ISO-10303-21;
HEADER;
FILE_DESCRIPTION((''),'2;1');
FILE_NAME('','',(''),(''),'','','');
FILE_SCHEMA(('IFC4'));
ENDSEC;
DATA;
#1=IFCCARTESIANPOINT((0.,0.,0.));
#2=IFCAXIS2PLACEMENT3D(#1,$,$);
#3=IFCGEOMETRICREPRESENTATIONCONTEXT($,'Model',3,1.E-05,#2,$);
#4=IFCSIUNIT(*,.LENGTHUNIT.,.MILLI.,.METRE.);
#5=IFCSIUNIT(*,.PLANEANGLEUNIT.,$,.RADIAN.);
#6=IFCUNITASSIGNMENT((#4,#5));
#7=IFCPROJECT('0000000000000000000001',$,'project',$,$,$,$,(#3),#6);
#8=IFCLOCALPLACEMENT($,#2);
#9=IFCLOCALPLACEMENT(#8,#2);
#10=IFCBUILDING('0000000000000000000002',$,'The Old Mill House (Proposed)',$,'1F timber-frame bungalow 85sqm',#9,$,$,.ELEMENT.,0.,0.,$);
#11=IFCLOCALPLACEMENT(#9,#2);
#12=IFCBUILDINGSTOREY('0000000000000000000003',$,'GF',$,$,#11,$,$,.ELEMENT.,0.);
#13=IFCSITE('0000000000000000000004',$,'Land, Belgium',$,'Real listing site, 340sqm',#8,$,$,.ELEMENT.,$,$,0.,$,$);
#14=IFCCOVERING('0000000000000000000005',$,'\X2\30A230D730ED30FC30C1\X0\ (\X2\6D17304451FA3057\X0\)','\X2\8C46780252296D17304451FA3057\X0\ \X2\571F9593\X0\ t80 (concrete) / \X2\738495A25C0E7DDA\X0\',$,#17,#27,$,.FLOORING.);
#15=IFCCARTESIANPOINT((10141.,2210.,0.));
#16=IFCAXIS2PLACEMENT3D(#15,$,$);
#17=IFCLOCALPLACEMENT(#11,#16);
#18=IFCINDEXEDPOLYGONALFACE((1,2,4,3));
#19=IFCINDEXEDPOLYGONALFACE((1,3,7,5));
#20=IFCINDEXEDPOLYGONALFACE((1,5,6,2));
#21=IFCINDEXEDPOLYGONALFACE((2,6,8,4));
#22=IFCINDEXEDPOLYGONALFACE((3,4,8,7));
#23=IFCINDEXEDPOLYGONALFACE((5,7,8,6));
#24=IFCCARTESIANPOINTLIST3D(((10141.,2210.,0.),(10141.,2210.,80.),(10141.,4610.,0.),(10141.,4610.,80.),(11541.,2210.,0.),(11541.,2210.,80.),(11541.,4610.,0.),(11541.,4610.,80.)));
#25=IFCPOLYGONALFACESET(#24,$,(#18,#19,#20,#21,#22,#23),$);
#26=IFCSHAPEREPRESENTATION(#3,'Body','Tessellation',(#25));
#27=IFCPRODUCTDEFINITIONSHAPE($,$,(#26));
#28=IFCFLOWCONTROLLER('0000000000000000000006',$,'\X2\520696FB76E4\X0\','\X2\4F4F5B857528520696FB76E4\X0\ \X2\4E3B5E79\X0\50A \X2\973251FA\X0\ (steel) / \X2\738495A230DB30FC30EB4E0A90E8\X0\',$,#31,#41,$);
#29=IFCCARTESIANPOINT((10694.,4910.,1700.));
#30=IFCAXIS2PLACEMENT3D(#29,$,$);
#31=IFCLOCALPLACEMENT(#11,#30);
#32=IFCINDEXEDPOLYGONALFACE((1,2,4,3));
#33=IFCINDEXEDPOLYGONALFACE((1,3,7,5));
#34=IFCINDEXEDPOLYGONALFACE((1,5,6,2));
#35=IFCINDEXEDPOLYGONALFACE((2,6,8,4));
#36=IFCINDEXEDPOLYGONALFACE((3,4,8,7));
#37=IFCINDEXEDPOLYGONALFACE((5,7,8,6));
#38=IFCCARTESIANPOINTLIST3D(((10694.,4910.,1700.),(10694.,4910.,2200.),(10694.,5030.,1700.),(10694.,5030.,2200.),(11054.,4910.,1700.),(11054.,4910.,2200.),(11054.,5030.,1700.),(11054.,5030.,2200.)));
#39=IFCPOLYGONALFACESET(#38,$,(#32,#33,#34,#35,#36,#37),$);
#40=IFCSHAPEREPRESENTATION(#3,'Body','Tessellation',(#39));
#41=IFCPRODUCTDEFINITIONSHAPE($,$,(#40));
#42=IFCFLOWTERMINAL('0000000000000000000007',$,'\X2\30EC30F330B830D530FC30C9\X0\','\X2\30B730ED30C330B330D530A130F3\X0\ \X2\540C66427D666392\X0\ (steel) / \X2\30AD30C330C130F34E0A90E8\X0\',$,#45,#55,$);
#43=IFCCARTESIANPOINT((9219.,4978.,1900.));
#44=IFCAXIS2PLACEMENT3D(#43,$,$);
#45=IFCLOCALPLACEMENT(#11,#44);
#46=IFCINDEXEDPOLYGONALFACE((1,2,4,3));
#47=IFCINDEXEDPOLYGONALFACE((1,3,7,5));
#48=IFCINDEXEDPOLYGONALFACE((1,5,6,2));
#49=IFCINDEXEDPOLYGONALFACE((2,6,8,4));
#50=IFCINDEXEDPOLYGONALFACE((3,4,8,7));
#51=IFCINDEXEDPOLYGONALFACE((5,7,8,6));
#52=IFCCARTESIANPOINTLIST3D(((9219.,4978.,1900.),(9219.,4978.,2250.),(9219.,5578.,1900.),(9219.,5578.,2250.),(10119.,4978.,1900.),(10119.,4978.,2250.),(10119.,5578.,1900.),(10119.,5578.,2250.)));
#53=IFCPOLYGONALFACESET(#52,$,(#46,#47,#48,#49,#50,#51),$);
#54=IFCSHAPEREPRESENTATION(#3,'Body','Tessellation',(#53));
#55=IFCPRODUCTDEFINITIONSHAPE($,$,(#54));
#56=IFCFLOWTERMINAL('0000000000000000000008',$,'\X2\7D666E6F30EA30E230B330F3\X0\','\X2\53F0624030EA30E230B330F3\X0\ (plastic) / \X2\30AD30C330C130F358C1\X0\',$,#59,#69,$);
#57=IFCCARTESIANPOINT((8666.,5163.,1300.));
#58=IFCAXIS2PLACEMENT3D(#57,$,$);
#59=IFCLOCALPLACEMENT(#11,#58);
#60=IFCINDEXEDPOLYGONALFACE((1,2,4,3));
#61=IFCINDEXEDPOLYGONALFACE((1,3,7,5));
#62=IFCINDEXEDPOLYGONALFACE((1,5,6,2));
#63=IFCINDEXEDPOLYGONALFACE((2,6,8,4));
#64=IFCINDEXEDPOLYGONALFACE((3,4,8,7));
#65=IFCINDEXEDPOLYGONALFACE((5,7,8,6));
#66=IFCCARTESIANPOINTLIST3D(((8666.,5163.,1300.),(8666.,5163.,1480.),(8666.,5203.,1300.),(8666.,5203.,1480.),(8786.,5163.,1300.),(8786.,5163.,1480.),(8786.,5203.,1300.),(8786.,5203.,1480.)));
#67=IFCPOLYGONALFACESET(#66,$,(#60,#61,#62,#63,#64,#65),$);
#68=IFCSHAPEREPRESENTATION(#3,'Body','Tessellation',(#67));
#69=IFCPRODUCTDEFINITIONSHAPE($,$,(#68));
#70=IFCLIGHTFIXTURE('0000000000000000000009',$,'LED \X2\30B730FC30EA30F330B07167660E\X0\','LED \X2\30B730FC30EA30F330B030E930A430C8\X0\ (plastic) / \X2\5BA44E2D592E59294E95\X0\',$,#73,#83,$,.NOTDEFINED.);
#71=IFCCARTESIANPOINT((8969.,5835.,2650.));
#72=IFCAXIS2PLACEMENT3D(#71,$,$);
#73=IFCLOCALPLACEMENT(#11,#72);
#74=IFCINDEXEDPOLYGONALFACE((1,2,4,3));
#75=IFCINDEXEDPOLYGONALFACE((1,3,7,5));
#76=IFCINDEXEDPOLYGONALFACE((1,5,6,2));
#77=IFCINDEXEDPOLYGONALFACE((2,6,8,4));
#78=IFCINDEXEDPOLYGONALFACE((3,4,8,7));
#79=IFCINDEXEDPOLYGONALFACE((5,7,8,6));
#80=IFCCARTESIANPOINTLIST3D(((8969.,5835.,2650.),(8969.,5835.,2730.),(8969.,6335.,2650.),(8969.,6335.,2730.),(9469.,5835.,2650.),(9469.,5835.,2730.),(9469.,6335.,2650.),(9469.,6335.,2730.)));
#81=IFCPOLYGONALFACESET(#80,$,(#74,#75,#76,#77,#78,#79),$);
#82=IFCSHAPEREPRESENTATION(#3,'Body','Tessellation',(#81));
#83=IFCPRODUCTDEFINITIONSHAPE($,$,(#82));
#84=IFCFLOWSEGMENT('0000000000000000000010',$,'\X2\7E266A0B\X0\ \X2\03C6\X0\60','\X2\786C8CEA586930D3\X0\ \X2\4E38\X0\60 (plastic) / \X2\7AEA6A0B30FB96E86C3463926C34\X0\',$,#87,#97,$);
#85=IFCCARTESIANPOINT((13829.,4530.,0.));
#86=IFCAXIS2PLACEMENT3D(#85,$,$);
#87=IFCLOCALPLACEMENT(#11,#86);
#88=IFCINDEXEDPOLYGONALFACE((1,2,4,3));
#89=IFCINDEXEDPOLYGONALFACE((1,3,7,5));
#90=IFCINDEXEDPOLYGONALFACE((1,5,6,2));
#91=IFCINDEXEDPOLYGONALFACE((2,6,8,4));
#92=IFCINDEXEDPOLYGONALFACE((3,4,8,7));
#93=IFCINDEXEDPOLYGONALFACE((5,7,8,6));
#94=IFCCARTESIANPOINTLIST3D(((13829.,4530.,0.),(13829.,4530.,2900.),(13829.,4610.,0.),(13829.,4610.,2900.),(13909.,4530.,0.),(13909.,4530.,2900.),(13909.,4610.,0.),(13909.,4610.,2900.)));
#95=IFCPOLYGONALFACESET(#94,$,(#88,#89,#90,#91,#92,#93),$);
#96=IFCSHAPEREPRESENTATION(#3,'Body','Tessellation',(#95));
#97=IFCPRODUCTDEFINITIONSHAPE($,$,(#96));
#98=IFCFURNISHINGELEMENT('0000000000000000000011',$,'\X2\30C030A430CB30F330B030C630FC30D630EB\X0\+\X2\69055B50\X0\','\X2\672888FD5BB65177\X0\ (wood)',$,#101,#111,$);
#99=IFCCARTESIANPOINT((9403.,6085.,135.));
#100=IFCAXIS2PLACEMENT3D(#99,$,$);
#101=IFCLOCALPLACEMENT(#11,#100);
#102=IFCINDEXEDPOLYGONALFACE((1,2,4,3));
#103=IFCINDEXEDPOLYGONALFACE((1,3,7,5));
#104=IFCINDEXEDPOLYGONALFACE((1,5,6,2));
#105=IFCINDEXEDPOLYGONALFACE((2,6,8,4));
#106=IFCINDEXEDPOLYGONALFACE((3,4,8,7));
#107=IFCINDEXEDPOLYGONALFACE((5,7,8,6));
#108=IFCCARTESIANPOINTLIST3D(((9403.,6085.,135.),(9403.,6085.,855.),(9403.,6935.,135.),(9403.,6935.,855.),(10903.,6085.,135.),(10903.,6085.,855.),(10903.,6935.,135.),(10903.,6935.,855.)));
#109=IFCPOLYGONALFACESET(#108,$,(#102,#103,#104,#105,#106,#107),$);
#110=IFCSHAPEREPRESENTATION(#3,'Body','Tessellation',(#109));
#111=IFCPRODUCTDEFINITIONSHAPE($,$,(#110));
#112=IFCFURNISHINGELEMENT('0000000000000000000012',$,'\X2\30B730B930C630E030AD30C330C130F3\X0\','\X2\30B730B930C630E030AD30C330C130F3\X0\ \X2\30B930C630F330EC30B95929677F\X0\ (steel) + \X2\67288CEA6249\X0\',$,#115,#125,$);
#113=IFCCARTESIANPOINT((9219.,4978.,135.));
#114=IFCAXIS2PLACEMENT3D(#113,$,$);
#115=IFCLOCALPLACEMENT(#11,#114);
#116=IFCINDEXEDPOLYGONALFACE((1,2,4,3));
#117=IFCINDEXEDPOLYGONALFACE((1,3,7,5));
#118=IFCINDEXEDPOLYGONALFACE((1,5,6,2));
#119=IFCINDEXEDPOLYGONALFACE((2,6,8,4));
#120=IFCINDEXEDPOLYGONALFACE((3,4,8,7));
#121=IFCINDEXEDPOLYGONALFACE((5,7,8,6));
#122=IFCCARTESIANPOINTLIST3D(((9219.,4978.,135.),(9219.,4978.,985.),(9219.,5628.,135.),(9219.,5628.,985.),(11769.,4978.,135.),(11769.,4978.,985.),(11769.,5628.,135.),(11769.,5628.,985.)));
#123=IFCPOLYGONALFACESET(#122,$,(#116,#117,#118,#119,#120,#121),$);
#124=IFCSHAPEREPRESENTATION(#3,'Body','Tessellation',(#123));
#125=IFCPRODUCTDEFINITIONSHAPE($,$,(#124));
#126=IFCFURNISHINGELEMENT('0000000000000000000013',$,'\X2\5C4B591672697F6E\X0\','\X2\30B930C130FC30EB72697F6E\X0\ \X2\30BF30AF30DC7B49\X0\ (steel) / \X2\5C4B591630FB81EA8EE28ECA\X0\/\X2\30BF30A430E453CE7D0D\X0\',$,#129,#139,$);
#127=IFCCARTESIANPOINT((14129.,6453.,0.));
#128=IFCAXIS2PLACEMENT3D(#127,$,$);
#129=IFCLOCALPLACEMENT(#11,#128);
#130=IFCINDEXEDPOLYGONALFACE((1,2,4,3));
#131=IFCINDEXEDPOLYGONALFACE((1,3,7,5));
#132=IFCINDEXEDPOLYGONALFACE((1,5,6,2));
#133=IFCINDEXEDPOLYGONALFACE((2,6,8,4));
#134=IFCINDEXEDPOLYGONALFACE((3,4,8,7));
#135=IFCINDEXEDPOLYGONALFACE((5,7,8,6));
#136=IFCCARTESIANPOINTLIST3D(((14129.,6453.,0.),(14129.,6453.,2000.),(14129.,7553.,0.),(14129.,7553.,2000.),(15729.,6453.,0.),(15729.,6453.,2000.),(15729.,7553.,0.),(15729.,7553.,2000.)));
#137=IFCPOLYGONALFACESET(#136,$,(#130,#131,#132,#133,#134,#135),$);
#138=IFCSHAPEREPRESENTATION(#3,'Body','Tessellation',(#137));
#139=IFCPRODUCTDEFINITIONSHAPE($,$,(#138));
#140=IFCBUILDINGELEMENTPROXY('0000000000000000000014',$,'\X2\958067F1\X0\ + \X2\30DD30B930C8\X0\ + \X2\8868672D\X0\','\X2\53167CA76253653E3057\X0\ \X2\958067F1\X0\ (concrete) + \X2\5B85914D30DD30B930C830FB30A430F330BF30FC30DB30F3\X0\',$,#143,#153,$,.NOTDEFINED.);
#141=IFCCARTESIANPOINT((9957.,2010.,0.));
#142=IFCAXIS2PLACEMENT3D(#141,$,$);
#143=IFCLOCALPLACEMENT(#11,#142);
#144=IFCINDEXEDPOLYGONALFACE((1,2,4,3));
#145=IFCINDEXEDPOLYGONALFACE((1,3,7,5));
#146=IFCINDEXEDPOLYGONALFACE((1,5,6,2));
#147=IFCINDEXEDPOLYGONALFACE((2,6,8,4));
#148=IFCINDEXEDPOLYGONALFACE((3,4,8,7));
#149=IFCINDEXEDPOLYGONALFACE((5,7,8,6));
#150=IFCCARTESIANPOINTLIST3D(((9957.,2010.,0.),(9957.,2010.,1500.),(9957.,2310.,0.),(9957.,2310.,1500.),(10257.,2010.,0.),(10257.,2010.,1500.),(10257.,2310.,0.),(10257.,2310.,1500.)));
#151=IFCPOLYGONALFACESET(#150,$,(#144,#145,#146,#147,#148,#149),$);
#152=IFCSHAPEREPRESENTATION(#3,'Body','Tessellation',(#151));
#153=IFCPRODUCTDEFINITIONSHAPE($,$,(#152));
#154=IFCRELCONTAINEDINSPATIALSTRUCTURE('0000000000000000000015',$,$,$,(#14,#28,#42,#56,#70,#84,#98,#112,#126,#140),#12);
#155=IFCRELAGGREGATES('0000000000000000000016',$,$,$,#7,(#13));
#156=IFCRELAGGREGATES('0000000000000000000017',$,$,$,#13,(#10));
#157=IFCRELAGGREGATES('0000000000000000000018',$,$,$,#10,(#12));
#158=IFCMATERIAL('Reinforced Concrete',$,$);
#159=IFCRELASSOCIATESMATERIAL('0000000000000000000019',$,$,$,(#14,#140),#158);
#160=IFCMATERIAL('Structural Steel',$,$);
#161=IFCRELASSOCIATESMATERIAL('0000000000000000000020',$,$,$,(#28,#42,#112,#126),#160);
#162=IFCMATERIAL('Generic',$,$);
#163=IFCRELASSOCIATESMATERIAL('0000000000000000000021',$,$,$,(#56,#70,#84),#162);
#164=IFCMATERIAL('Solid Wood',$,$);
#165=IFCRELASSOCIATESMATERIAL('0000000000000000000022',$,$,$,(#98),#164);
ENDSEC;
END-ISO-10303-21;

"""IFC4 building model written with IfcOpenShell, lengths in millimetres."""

from ifc_helpers import new_model, si_unit, frame, frame_2d, origin, place, context, project, spatial, rectangle, extrude, material, element, save


model = new_model("IFC4")

# Units and contexts
model_context = context("Model", 3, precision=1e-05, world=origin())
ifc_project = project(units=[si_unit("LENGTHUNIT", "METRE", prefix="MILLI"), si_unit("PLANEANGLEUNIT", "RADIAN")], contexts=[model_context])

# Site, building, storey
site_placement = place(None, origin())
site = spatial("IfcSite", under=ifc_project, at=site_placement, Name="Land, Belgium", ObjectType="Real listing site, 340sqm", CompositionType="ELEMENT", RefElevation=0.0)
building_placement = place(site_placement, origin())
building = spatial("IfcBuilding", under=site, at=building_placement, Name="The Old Mill House (Proposed)", ObjectType="1F timber-frame bungalow 85sqm", CompositionType="ELEMENT", ElevationOfRefHeight=0.0, ElevationOfTerrain=0.0)
storey_placement = place(building_placement, origin())
storey = spatial("IfcBuildingStorey", under=building, at=storey_placement, Name="GF", CompositionType="ELEMENT", Elevation=0.0)

# Shared definitions
ifc_material_1 = material(Name="Solid Wood")

# Shared definitions
ifc_material_2 = material(Name="Structural Steel")

# Covering
ifc_material_3 = material(Name="Reinforced Concrete")
covering_placement = place(storey_placement, frame((10141.0, 2210.0, 0.0)))
element("IfcCovering", 1, at=covering_placement, inside=storey, material=ifc_material_3, Name="アプローチ (洗い出し)", Description="豆砂利洗い出し 土間 t80 (concrete) / 玄関導線", PredefinedType="FLOORING", context=model_context, shape_type="SweptSolid", body=[
    extrude(rectangle(XDim=1400.0, YDim=2400.0, at=frame_2d((700.0, 1200.0))), frame((10141.0, 2210.0, 0.0)), (0.0, 0.0, 1.0), 80.0),
])

# Flow controller
flow_controller_placement = place(storey_placement, frame((10694.0, 4910.0, 1700.0)))
element("IfcFlowController", 2, at=flow_controller_placement, inside=storey, material=ifc_material_2, Name="分電盤", Description="住宅用分電盤 主幹50A 露出 (steel) / 玄関ホール上部", context=model_context, shape_type="SweptSolid", body=[
    extrude(rectangle(XDim=360.0, YDim=120.0, at=frame_2d((180.0, 60.0))), frame((10694.0, 4910.0, 1700.0)), (0.0, 0.0, 1.0), 500.0),
])

# Flow terminals
flow_terminal_1_placement = place(storey_placement, frame((9219.0, 4978.0, 1900.0)))
element("IfcFlowTerminal", 3, at=flow_terminal_1_placement, inside=storey, material=ifc_material_2, Name="レンジフード", Description="シロッコファン 同時給排 (steel) / キッチン上部", context=model_context, shape_type="SweptSolid", body=[
    extrude(rectangle(XDim=900.0, YDim=600.0, at=frame_2d((450.0, 300.0))), frame((9219.0, 4978.0, 1900.0)), (0.0, 0.0, 1.0), 350.0),
])
ifc_material_4 = material(Name="Generic")
flow_terminal_2_placement = place(storey_placement, frame((8666.0, 5163.0, 1300.0)))
element("IfcFlowTerminal", 4, at=flow_terminal_2_placement, inside=storey, material=ifc_material_4, Name="給湯リモコン", Description="台所リモコン (plastic) / キッチン壁", context=model_context, shape_type="SweptSolid", body=[
    extrude(rectangle(XDim=120.0, YDim=40.0, at=frame_2d((60.0, 20.0))), frame((8666.0, 5163.0, 1300.0)), (0.0, 0.0, 1.0), 180.0),
])

# Light fixture
light_fixture_placement = place(storey_placement, frame((8969.0, 5835.0, 2650.0)))
element("IfcLightFixture", 5, at=light_fixture_placement, inside=storey, material=ifc_material_4, Name="LED シーリング照明", Description="LED シーリングライト (plastic) / 室中央天井", PredefinedType="NOTDEFINED", context=model_context, shape_type="SweptSolid", body=[
    extrude(rectangle(XDim=500.0, YDim=500.0, at=frame_2d((250.0, 250.0))), frame((8969.0, 5835.0, 2650.0)), (0.0, 0.0, 1.0), 80.0),
])

# Flow segment
flow_segment_placement = place(storey_placement, frame((13829.0, 4530.0, 0.0)))
element("IfcFlowSegment", 6, at=flow_segment_placement, inside=storey, material=ifc_material_4, Name="縦樋 φ60", Description="硬質塩ビ 丸60 (plastic) / 竪樋・雨水排水", context=model_context, shape_type="SweptSolid", body=[
    extrude(rectangle(XDim=80.0, YDim=80.0, at=frame_2d((40.0, 40.0))), frame((13829.0, 4530.0, 0.0)), (0.0, 0.0, 1.0), 2900.0),
])

# Furnishing elements
furnishing_1_placement = place(storey_placement, frame((9403.0, 6085.0, 135.0)))
element("IfcFurnishingElement", 7, at=furnishing_1_placement, inside=storey, material=ifc_material_1, Name="ダイニングテーブル+椅子", Description="木製家具 (wood)", context=model_context, shape_type="SweptSolid", body=[
    extrude(rectangle(XDim=1500.0, YDim=850.0, at=frame_2d((750.0, 425.0))), frame((9403.0, 6085.0, 135.0)), (0.0, 0.0, 1.0), 720.0),
])
furnishing_2_placement = place(storey_placement, frame((9219.0, 4978.0, 135.0)))
element("IfcFurnishingElement", 8, at=furnishing_2_placement, inside=storey, material=ifc_material_2, Name="システムキッチン", Description="システムキッチン ステンレス天板 (steel) + 木質扉", context=model_context, shape_type="SweptSolid", body=[
    extrude(rectangle(XDim=2550.0, YDim=650.0, at=frame_2d((1275.0, 325.0))), frame((9219.0, 4978.0, 135.0)), (0.0, 0.0, 1.0), 850.0),
])
furnishing_3_placement = place(storey_placement, frame((14129.0, 6453.0, 0.0)))
element("IfcFurnishingElement", 9, at=furnishing_3_placement, inside=storey, material=ifc_material_2, Name="屋外物置", Description="スチール物置 タクボ等 (steel) / 屋外・自転車/タイヤ収納", context=model_context, shape_type="SweptSolid", body=[
    extrude(rectangle(XDim=1600.0, YDim=1100.0, at=frame_2d((800.0, 550.0))), frame((14129.0, 6453.0, 0.0)), (0.0, 0.0, 1.0), 2000.0),
])

# Building element proxy
proxy_placement = place(storey_placement, frame((9957.0, 2010.0, 0.0)))
element("IfcBuildingElementProxy", 10, at=proxy_placement, inside=storey, material=ifc_material_3, Name="門柱 + ポスト + 表札", Description="化粧打放し 門柱 (concrete) + 宅配ポスト・インターホン", PredefinedType="NOTDEFINED", context=model_context, shape_type="SweptSolid", body=[
    extrude(rectangle(XDim=300.0, YDim=300.0, at=frame_2d((150.0, 150.0))), frame((9957.0, 2010.0, 0.0)), (0.0, 0.0, 1.0), 1500.0),
])

save(model, "model.ifc")
